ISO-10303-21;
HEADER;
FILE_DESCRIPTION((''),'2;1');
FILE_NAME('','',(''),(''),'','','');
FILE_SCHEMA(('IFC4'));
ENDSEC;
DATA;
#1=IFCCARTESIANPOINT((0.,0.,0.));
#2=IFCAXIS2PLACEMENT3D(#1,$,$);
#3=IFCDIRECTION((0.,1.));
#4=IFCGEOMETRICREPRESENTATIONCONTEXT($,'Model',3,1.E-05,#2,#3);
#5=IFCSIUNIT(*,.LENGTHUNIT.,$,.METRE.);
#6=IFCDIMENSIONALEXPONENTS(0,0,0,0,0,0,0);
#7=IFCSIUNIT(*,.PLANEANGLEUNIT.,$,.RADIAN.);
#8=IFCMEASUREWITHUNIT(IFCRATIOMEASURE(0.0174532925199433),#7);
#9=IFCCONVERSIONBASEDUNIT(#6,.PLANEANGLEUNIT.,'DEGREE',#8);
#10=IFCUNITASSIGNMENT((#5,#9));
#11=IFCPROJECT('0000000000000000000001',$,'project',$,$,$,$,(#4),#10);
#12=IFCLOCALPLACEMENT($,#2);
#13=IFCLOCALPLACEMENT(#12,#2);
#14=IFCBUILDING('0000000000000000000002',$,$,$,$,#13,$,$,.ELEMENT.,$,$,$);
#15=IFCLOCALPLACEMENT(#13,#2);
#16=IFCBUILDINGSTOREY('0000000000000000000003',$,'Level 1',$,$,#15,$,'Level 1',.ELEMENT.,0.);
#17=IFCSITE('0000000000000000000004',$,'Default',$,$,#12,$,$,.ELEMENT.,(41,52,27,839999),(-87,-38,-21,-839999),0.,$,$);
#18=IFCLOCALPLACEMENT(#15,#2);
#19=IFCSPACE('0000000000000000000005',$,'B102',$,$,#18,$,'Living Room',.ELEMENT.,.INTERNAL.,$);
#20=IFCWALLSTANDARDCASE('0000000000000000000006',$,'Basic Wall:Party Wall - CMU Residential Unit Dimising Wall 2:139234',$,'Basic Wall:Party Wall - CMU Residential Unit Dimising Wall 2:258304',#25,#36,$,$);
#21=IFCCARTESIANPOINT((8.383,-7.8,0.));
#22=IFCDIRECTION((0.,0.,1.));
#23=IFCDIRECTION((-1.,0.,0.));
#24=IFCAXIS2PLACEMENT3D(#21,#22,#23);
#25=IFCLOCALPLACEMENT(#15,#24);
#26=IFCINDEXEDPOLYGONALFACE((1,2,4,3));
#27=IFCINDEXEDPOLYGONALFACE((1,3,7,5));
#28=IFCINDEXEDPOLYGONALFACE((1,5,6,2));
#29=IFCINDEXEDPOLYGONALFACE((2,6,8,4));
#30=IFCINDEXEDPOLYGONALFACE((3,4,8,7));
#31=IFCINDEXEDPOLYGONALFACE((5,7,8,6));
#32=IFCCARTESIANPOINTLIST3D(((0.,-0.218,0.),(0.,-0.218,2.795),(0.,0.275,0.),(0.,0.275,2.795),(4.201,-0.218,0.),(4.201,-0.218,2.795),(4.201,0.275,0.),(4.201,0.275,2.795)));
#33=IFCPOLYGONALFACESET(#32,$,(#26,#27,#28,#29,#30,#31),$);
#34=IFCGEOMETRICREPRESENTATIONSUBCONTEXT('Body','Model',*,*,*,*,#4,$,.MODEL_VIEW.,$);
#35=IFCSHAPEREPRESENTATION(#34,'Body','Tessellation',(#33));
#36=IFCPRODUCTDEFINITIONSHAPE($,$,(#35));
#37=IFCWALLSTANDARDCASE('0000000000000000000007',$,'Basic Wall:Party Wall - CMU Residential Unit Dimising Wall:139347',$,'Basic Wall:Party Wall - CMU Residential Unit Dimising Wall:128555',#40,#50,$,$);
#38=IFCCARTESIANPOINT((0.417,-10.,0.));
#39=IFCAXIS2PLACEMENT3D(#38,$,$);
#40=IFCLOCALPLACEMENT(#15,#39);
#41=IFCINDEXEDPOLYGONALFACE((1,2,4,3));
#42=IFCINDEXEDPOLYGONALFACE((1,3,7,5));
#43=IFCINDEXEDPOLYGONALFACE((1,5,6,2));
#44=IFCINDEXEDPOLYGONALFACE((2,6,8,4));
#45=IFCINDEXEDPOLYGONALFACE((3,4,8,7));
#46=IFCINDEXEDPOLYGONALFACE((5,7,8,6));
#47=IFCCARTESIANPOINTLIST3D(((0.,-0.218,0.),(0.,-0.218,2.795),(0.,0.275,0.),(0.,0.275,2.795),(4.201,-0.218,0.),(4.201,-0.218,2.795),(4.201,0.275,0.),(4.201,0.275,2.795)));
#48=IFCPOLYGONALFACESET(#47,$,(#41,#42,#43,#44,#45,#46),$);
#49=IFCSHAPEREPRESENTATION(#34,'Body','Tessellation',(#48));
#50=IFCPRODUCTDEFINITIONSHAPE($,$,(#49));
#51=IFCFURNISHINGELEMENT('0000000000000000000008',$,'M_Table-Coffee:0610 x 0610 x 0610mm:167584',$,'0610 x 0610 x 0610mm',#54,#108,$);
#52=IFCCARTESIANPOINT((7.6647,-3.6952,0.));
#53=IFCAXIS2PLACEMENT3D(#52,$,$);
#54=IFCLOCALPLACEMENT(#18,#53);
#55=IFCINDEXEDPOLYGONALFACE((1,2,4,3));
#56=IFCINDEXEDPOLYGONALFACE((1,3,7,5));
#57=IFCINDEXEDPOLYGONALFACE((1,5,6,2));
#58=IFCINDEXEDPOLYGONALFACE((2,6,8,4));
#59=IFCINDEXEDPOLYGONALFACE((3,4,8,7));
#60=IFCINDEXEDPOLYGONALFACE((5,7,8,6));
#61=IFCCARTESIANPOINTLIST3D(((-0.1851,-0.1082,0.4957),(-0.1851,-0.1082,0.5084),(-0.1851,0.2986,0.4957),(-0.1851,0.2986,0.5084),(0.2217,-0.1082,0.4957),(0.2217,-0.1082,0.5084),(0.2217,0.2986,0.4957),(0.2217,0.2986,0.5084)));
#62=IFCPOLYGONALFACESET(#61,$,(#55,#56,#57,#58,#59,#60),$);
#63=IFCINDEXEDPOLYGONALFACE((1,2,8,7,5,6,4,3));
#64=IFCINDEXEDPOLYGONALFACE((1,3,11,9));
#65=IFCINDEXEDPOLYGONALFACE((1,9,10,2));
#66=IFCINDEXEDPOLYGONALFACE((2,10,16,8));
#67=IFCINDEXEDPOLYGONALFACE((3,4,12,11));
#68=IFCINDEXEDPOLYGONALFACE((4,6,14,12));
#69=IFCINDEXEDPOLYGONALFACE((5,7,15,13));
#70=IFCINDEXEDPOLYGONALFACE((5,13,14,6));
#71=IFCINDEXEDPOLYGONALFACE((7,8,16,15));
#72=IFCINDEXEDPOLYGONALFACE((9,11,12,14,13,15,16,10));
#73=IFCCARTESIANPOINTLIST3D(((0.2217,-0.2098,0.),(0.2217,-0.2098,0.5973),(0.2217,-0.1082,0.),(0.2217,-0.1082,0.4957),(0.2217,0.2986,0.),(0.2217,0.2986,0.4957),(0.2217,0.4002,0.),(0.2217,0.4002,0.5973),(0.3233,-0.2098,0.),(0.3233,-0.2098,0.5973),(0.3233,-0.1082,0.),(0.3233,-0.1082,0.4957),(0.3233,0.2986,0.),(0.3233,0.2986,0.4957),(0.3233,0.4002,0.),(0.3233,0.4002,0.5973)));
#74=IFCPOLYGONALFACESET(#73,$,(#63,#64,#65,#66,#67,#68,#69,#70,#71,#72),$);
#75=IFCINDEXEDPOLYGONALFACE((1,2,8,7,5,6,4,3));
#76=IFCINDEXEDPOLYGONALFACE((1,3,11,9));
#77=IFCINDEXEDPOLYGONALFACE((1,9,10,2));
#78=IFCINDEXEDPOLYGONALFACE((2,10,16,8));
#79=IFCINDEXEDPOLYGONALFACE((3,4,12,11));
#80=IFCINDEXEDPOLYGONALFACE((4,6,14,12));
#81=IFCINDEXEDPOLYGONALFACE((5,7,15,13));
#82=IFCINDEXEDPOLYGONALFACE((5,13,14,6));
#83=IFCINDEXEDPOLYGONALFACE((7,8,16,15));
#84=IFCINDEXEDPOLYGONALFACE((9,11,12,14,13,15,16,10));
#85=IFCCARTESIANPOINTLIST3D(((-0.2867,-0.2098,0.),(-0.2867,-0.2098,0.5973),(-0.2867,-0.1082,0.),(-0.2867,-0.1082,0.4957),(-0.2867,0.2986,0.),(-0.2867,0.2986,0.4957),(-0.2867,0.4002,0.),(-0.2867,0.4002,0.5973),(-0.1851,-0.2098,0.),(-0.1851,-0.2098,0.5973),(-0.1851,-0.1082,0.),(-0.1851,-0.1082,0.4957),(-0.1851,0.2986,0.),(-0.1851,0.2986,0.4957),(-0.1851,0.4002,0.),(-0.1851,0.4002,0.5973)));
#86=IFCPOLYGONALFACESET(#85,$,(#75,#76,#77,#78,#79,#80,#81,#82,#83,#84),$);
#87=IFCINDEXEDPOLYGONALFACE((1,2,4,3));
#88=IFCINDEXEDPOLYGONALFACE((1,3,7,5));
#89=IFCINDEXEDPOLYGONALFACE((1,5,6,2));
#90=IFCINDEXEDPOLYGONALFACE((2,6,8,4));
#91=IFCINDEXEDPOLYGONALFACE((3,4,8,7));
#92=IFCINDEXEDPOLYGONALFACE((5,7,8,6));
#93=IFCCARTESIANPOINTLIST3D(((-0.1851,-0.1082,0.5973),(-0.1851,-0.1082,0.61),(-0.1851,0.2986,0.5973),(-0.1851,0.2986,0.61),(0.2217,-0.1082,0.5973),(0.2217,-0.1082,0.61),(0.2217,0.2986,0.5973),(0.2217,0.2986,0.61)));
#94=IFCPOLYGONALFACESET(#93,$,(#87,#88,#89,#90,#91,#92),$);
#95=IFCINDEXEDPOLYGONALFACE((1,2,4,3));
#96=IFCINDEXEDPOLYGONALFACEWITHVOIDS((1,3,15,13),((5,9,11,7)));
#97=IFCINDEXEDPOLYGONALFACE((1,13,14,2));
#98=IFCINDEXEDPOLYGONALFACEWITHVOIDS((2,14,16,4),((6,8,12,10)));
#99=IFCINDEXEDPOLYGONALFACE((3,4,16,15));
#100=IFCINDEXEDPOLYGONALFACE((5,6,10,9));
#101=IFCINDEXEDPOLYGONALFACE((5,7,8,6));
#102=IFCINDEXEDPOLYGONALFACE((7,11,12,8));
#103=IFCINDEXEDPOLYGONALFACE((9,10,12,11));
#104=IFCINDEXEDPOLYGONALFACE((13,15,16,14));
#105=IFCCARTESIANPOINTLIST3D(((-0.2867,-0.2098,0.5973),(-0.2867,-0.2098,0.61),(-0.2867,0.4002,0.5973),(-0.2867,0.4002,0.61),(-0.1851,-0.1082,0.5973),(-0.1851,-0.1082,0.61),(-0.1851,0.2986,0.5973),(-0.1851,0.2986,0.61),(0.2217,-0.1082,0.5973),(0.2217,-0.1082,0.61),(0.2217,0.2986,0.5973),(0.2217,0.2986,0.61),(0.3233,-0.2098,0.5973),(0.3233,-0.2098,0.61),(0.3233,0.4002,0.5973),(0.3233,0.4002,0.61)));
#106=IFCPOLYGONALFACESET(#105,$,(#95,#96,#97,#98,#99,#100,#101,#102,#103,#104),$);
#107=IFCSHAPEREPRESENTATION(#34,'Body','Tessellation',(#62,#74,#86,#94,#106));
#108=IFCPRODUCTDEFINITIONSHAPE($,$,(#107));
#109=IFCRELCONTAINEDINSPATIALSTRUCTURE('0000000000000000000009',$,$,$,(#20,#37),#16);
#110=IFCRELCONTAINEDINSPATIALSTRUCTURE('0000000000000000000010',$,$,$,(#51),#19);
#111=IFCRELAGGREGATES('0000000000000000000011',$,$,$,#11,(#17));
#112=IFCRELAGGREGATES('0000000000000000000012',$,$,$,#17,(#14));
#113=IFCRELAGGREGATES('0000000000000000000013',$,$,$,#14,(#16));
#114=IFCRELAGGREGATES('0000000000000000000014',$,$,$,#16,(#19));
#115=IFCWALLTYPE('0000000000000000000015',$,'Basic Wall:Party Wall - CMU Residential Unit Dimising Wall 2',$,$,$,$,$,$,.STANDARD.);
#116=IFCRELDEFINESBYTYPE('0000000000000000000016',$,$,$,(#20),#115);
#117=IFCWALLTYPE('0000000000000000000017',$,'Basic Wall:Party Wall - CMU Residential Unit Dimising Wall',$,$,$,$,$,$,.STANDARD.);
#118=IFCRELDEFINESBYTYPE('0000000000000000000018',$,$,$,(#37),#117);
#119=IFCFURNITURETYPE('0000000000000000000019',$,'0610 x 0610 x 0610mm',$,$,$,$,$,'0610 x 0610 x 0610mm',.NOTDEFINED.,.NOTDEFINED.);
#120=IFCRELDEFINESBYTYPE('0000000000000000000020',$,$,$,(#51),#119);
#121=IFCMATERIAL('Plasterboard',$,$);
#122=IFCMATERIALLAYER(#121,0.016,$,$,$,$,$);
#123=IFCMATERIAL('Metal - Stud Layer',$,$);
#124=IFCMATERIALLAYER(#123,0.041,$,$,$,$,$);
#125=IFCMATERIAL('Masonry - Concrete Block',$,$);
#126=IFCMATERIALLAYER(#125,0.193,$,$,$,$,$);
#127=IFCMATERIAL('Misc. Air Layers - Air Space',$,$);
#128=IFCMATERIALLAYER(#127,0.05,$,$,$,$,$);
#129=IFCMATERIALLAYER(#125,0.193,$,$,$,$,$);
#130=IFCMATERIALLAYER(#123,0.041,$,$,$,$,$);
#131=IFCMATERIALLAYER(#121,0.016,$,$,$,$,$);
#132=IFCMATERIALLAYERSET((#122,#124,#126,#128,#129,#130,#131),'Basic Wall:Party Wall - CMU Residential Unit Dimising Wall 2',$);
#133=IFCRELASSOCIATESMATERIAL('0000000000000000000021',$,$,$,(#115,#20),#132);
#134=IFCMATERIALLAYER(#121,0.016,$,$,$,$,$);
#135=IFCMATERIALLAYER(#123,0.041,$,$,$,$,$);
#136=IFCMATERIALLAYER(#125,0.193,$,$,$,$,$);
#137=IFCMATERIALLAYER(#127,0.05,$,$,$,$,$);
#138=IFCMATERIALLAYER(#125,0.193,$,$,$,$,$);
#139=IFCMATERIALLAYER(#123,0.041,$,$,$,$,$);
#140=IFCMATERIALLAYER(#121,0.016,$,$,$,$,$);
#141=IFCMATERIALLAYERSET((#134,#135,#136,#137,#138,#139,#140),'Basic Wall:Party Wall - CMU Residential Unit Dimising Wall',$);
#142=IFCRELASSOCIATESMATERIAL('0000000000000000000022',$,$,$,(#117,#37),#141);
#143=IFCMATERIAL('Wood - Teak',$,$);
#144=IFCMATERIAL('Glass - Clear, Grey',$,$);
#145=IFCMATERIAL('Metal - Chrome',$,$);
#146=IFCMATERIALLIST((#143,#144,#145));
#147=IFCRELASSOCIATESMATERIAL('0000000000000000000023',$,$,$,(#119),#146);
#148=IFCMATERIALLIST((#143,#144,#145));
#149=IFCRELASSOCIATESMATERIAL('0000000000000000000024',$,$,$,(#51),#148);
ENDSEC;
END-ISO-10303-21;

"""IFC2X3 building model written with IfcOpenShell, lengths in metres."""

from ifc_helpers import new_model, entity, si_unit, converted_unit, direction, frame, frame_2d, origin, origin_2d_with_axis, place, context, subcontext, project, spatial, polyline, rectangle, outline, extrude, clip, bounded_halfspace, source, transform, mapped, material, material_list, layer, layer_set, layer_usage, type_object, type_shapes, element, save


model = new_model("IFC2X3")

# Units and contexts
model_context = context("Model", 3, precision=1e-05, world=origin(), true_north=direction((0.0, 1.0)))
body_context = subcontext(model_context, "Body", "Model", "MODEL_VIEW")
ifc_project = project(units=[si_unit("LENGTHUNIT", "METRE"), converted_unit("PLANEANGLEUNIT", "DEGREE", entity("IfcRatioMeasure", 0.0174532925199433), si_unit("PLANEANGLEUNIT", "RADIAN"), dimensions=[0, 0, 0, 0, 0, 0, 0])], contexts=[model_context])

# Site, building, storey
site_placement = place(None, origin())
site = spatial("IfcSite", under=ifc_project, at=site_placement, Name="Default", CompositionType="ELEMENT", RefLatitude=(41, 52, 27, 839999), RefLongitude=(-87, -38, -21, -839999), RefElevation=0.0)
building_placement = place(site_placement, origin())
building = spatial("IfcBuilding", under=site, at=building_placement, CompositionType="ELEMENT")
storey_placement = place(building_placement, origin())
storey = spatial("IfcBuildingStorey", under=building, at=storey_placement, Name="Level 1", LongName="Level 1", CompositionType="ELEMENT", Elevation=0.0)

# Shared definitions
ifc_material_1 = material(Name="Plasterboard")
ifc_material_2 = material(Name="Metal - Stud Layer")

# Walls
ifc_layer_1 = layer(ifc_material_1, 0.016)
ifc_layer_2 = layer(ifc_material_2, 0.041)
ifc_material_3 = material(Name="Masonry - Concrete Block")
ifc_layer_3 = layer(ifc_material_3, 0.193)
ifc_material_4 = material(Name="Misc. Air Layers - Air Space")
ifc_layer_4 = layer(ifc_material_4, 0.05)
ifc_layer_5 = layer(ifc_material_3, 0.193)
ifc_layer_6 = layer(ifc_material_2, 0.041)
ifc_layer_7 = layer(ifc_material_1, 0.016)
ifc_layer_set_1 = layer_set([ifc_layer_1, ifc_layer_2, ifc_layer_3, ifc_layer_4, ifc_layer_5, ifc_layer_6, ifc_layer_7], Name="Basic Wall:Party Wall - CMU Residential Unit Dimising Wall 2")
ifc_layer_usage_1 = layer_usage(ifc_layer_set_1, "AXIS2", "NEGATIVE", 0.275)
wall_type_1 = type_object("IfcWallType", Name="Basic Wall:Party Wall - CMU Residential Unit Dimising Wall 2", PredefinedType="STANDARD", material=ifc_layer_set_1)
wall_1_placement = place(storey_placement, frame((8.383, -7.8, 0.0), z_axis=(0.0, 0.0, 1.0), x_axis=(-1.0, 0.0, 0.0)))
element("IfcWallStandardCase", 1, at=wall_1_placement, inside=storey, type_object=wall_type_1, material=ifc_layer_usage_1, Name="Basic Wall:Party Wall - CMU Residential Unit Dimising Wall 2:139234", ObjectType="Basic Wall:Party Wall - CMU Residential Unit Dimising Wall 2:258304", context=body_context, shape_type="Clipping", body=[
    clip(clip(extrude(rectangle(XDim=4.201, YDim=0.55, at=frame_2d((2.1005, 0.0), x_axis=(-1.0, 0.0))), origin(), (0.0, 0.0, 1.0), 2.795), bounded_halfspace(frame((0.0, -0.218, 2.795), z_axis=(0.0, 1.0, 0.0), x_axis=(-1.0, 0.0, 0.0)), True, frame((0.0, -0.218, 2.795), z_axis=(0.0, 1.0, 0.0), x_axis=(-1.0, 0.0, 0.0)), polyline([(0.0, 0.0), (-3.708, 0.0), (-4.201, 0.0), (-4.201, -2.795), (0.0, -2.795), (0.0, 0.0)]))), bounded_halfspace(frame((4.201, 0.275, 0.0), z_axis=(-1.0, 0.0, 0.0), x_axis=(0.0, -1.0, 0.0)), True, frame((4.201, 0.275, 0.0), z_axis=(-1.0, 0.0, 0.0), x_axis=(0.0, -1.0, 0.0)), polyline([(0.0, 0.0), (0.493, 0.0), (0.493, 2.795), (0.0, 2.795), (0.0, 0.0)]))),
])
ifc_layer_8 = layer(ifc_material_1, 0.016)
ifc_layer_9 = layer(ifc_material_2, 0.041)
ifc_layer_10 = layer(ifc_material_3, 0.193)
ifc_layer_11 = layer(ifc_material_4, 0.05)
ifc_layer_12 = layer(ifc_material_3, 0.193)
ifc_layer_13 = layer(ifc_material_2, 0.041)
ifc_layer_14 = layer(ifc_material_1, 0.016)
ifc_layer_set_2 = layer_set([ifc_layer_8, ifc_layer_9, ifc_layer_10, ifc_layer_11, ifc_layer_12, ifc_layer_13, ifc_layer_14], Name="Basic Wall:Party Wall - CMU Residential Unit Dimising Wall")
ifc_layer_usage_2 = layer_usage(ifc_layer_set_2, "AXIS2", "NEGATIVE", 0.275)
wall_type_2 = type_object("IfcWallType", Name="Basic Wall:Party Wall - CMU Residential Unit Dimising Wall", PredefinedType="STANDARD", material=ifc_layer_set_2)
wall_2_placement = place(storey_placement, frame((0.417, -10.0, 0.0)))
element("IfcWallStandardCase", 2, at=wall_2_placement, inside=storey, type_object=wall_type_2, material=ifc_layer_usage_2, Name="Basic Wall:Party Wall - CMU Residential Unit Dimising Wall:139347", ObjectType="Basic Wall:Party Wall - CMU Residential Unit Dimising Wall:128555", context=body_context, shape_type="Clipping", body=[
    clip(clip(extrude(rectangle(XDim=4.201, YDim=0.55, at=frame_2d((2.1005, 0.0), x_axis=(-1.0, 0.0))), origin(), (0.0, 0.0, 1.0), 2.795), bounded_halfspace(frame((0.0, -0.218, 0.0), z_axis=(0.0, 1.0, 0.0), x_axis=(-1.0, 0.0, 0.0)), True, frame((0.0, -0.218, 0.0), z_axis=(0.0, 1.0, 0.0), x_axis=(-1.0, 0.0, 0.0)), polyline([(0.0, 0.0), (0.0, 2.795), (-4.201, 2.795), (-4.201, 0.0), (0.0, 0.0)]))), bounded_halfspace(frame((4.201, 0.275, 0.0), z_axis=(-1.0, 0.0, 0.0), x_axis=(0.0, -1.0, 0.0)), True, frame((4.201, 0.275, 0.0), z_axis=(-1.0, 0.0, 0.0), x_axis=(0.0, -1.0, 0.0)), polyline([(0.0, 0.0), (0.493, 0.0), (0.493, 2.795), (0.0, 2.795), (0.0, 0.0)]))),
])

# Shared definitions
space_1_placement = place(storey_placement, origin())
space_1 = spatial("IfcSpace", under=storey, at=space_1_placement, Name="B102", LongName="Living Room", CompositionType="ELEMENT", InteriorOrExteriorSpace="INTERNAL")

# Furnishing element
ifc_material_5 = material(Name="Wood - Teak")
ifc_material_6 = material(Name="Glass - Clear, Grey")
ifc_material_7 = material(Name="Metal - Chrome")
ifc_material_list_1 = material_list([ifc_material_5, ifc_material_6, ifc_material_7])
ifc_material_list_2 = material_list([ifc_material_5, ifc_material_6, ifc_material_7])
furniture_type_1 = type_object("IfcFurnitureType", Name="0610 x 0610 x 0610mm", ElementType="0610 x 0610 x 0610mm", material=ifc_material_list_2)
shared_shape_1 = source(origin(), body_context, "Body", "SweptSolid", [
    extrude(rectangle(XDim=0.4068, YDim=0.4068, at=origin_2d_with_axis()), frame((0.0183, 0.0952, 0.4957), z_axis=(0.0, 0.0, 1.0), x_axis=(-1.0, 0.0, 0.0)), (0.0, 0.0, 1.0), 0.0127),
    extrude(outline(polyline([(-0.2732, -0.305), (0.324, -0.305), (0.324, 0.305), (-0.2732, 0.305), (-0.2732, 0.2034), (0.2225, 0.2034), (0.2225, -0.2034), (-0.2732, -0.2034), (-0.2732, -0.305)])), frame((0.2217, 0.0952, 0.2732), z_axis=(1.0, 0.0, 0.0), x_axis=(0.0, 0.0, 1.0)), (0.0, 0.0, 1.0), 0.1016),
    extrude(outline(polyline([(-0.305, -0.3241), (0.305, -0.3241), (0.305, 0.2733), (0.2034, 0.2733), (0.2034, -0.2224), (-0.2034, -0.2224), (-0.2034, 0.2733), (-0.305, 0.2733), (-0.305, -0.3241)])), frame((-0.2867, 0.0952, 0.2733), z_axis=(1.0, 0.0, 0.0), x_axis=(0.0, -1.0, 0.0)), (0.0, 0.0, 1.0), 0.1016),
    extrude(rectangle(XDim=0.4068, YDim=0.4068, at=origin_2d_with_axis()), frame((0.0183, 0.0952, 0.5973), z_axis=(0.0, 0.0, 1.0), x_axis=(-1.0, 0.0, 0.0)), (0.0, 0.0, 1.0), 0.0127),
    extrude(outline(polyline([(-0.305, -0.305), (0.305, -0.305), (0.305, 0.305), (-0.305, 0.305), (-0.305, -0.305)]), holes=[polyline([(-0.2034, -0.2034), (-0.2034, 0.2034), (0.2034, 0.2034), (0.2034, -0.2034), (-0.2034, -0.2034)])]), frame((0.0183, 0.0952, 0.5973), z_axis=(0.0, 0.0, 1.0), x_axis=(-1.0, 0.0, 0.0)), (0.0, 0.0, 1.0), 0.0127),
])
type_shapes(furniture_type_1, [shared_shape_1])
furnishing_1_placement = place(space_1_placement, frame((7.6647, -3.6952, 0.0)))
element("IfcFurnishingElement", 3, at=furnishing_1_placement, inside=space_1, type_object=furniture_type_1, material=ifc_material_list_1, Name="M_Table-Coffee:0610 x 0610 x 0610mm:167584", ObjectType="0610 x 0610 x 0610mm", context=body_context, shape_type="MappedRepresentation", body=[
    mapped(shared_shape_1, transform((0.0, 0.0, 0.0), scale=1.0)),
])

save(model, "model.ifc")
